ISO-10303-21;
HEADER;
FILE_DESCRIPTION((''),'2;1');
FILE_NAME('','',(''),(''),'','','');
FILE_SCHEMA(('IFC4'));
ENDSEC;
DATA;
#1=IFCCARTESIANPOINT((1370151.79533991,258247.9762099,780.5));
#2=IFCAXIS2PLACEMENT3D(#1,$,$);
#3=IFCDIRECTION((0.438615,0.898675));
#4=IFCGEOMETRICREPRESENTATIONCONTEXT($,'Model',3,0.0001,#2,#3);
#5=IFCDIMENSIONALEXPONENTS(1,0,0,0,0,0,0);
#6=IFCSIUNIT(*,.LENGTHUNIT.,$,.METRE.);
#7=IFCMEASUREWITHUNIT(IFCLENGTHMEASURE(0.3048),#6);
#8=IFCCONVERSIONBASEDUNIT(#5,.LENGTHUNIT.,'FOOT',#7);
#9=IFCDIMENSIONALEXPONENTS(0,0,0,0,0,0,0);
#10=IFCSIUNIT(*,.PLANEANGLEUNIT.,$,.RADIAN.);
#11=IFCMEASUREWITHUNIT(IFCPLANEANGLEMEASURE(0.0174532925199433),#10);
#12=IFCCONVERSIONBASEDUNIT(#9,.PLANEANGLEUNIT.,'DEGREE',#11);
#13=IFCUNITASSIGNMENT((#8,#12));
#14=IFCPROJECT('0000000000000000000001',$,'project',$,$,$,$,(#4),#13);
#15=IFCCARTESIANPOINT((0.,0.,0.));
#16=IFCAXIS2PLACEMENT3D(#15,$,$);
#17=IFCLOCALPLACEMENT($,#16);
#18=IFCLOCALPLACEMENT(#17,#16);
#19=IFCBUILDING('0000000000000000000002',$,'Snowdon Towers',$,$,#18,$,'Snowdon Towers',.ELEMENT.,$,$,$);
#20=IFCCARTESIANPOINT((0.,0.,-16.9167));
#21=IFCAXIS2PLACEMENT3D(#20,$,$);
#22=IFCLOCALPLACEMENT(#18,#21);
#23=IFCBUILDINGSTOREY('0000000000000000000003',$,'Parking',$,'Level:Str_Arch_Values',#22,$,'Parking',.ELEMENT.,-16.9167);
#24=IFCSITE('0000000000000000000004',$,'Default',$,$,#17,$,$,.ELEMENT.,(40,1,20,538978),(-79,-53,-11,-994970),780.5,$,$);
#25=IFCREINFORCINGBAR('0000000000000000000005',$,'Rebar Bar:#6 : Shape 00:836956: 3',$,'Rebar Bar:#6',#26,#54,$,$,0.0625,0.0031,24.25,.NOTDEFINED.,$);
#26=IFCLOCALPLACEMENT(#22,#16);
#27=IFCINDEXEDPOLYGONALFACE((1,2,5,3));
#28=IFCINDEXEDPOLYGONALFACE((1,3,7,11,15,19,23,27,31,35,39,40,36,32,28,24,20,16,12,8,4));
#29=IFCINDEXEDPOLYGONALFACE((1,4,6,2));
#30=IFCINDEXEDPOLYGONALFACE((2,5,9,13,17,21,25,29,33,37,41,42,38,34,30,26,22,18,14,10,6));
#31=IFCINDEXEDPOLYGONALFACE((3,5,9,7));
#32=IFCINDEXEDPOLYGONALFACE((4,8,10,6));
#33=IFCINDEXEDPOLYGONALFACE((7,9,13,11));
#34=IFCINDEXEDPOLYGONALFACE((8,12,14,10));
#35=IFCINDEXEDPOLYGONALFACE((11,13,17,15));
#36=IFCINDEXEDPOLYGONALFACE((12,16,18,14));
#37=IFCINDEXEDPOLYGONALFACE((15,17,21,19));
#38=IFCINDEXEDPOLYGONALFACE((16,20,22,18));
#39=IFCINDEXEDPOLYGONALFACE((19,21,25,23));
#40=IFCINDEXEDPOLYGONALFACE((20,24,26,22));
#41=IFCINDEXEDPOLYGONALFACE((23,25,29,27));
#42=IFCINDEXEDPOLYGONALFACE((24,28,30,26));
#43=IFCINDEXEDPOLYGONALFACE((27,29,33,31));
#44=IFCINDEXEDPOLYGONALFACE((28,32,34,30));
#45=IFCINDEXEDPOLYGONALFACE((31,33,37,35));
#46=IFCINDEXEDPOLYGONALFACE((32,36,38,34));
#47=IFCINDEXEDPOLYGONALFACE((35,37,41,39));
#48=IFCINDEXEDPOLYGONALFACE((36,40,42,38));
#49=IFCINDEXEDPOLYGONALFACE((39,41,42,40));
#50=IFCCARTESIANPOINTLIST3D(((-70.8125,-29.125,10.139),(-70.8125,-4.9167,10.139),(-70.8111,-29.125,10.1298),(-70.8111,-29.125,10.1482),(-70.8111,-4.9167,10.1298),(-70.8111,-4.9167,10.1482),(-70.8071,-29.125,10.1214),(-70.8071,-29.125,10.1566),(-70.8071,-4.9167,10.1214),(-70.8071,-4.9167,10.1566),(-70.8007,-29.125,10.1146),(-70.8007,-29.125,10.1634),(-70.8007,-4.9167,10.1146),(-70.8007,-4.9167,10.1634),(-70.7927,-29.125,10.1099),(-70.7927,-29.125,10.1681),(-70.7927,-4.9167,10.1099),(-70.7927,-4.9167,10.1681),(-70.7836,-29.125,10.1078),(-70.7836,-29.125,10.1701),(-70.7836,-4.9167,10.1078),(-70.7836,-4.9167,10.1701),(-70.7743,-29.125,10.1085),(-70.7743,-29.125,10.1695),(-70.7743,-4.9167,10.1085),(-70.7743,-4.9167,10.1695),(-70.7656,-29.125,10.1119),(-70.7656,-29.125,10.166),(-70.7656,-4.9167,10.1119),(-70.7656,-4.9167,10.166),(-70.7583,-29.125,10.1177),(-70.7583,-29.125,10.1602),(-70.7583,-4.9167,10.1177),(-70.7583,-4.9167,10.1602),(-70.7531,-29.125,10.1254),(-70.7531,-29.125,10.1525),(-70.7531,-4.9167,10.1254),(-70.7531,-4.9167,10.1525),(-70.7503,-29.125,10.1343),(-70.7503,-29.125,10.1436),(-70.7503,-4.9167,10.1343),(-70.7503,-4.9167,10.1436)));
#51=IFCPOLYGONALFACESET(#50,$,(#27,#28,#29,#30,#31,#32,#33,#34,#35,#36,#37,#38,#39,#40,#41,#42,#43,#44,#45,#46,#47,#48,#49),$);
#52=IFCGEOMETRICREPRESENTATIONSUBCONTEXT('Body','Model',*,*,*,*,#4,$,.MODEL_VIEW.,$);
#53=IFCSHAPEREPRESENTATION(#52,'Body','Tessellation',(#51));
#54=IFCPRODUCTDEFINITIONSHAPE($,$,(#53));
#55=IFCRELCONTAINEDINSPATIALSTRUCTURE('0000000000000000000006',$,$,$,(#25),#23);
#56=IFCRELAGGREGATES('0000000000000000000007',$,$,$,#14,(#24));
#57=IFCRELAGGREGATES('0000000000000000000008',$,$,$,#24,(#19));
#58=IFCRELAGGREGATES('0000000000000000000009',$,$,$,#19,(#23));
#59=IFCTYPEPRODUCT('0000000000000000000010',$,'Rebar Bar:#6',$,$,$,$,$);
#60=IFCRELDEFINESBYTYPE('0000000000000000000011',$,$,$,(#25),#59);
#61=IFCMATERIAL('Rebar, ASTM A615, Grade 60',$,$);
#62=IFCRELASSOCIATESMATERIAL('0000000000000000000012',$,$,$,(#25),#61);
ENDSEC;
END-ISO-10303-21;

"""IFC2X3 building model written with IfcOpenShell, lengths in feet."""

from ifc_helpers import new_model, entity, si_unit, converted_unit, direction, frame, origin, place, context, subcontext, project, spatial, material, type_object, element, save


model = new_model("IFC2X3")

# Units and contexts
model_context = context("Model", 3, precision=0.0001, world=frame((1370151.79533991, 258247.9762099, 780.5)), true_north=direction((0.438615, 0.898675)))
body_context = subcontext(model_context, "Body", "Model", "MODEL_VIEW")
ifc_project = project(units=[converted_unit("LENGTHUNIT", "FOOT", entity("IfcLengthMeasure", 0.3048), si_unit("LENGTHUNIT", "METRE"), dimensions=[1, 0, 0, 0, 0, 0, 0]), converted_unit("PLANEANGLEUNIT", "DEGREE", entity("IfcPlaneAngleMeasure", 0.0174532925199433), si_unit("PLANEANGLEUNIT", "RADIAN"), dimensions=[0, 0, 0, 0, 0, 0, 0])], contexts=[model_context])

# Site, building, storey
site_placement = place(None, origin())
site = spatial("IfcSite", under=ifc_project, at=site_placement, Name="Default", CompositionType="ELEMENT", RefLatitude=(40, 1, 20, 538978), RefLongitude=(-79, -53, -11, -994970), RefElevation=780.5)
building_placement = place(site_placement, origin())
building = spatial("IfcBuilding", under=site, at=building_placement, Name="Snowdon Towers", LongName="Snowdon Towers", CompositionType="ELEMENT")
storey_placement = place(building_placement, frame((0.0, 0.0, -16.9167)))
storey = spatial("IfcBuildingStorey", under=building, at=storey_placement, Name="Parking", ObjectType="Level:Str_Arch_Values", LongName="Parking", CompositionType="ELEMENT", Elevation=-16.9167)

# Reinforcing bar
ifc_material = material(Name="Rebar, ASTM A615, Grade 60")
type_product = type_object("IfcTypeProduct", Name="Rebar Bar:#6")
reinforcing_bar_1_placement = place(storey_placement, origin())
element("IfcReinforcingBar", 1, at=reinforcing_bar_1_placement, inside=storey, type_object=type_product, material=ifc_material, Name="Rebar Bar:#6 : Shape 00:836956: 3", ObjectType="Rebar Bar:#6", BarLength=24.25, BarRole="NOTDEFINED", CrossSectionArea=0.0031, NominalDiameter=0.0625, context=body_context, shape_type="AdvancedSweptSolid", body=[
    entity("IfcSweptDiskSolid", entity("IfcCompositeCurve", [entity("IfcCompositeCurveSegment", "CONTINUOUS", True, entity("IfcPolyline", [entity("IfcCartesianPoint", [-70.7812, -4.9167, 10.139]), entity("IfcCartesianPoint", [-70.7812, -29.125, 10.139])]))], False), 0.0312, None, 0.0, 1.0),
])

save(model, "model.ifc")
